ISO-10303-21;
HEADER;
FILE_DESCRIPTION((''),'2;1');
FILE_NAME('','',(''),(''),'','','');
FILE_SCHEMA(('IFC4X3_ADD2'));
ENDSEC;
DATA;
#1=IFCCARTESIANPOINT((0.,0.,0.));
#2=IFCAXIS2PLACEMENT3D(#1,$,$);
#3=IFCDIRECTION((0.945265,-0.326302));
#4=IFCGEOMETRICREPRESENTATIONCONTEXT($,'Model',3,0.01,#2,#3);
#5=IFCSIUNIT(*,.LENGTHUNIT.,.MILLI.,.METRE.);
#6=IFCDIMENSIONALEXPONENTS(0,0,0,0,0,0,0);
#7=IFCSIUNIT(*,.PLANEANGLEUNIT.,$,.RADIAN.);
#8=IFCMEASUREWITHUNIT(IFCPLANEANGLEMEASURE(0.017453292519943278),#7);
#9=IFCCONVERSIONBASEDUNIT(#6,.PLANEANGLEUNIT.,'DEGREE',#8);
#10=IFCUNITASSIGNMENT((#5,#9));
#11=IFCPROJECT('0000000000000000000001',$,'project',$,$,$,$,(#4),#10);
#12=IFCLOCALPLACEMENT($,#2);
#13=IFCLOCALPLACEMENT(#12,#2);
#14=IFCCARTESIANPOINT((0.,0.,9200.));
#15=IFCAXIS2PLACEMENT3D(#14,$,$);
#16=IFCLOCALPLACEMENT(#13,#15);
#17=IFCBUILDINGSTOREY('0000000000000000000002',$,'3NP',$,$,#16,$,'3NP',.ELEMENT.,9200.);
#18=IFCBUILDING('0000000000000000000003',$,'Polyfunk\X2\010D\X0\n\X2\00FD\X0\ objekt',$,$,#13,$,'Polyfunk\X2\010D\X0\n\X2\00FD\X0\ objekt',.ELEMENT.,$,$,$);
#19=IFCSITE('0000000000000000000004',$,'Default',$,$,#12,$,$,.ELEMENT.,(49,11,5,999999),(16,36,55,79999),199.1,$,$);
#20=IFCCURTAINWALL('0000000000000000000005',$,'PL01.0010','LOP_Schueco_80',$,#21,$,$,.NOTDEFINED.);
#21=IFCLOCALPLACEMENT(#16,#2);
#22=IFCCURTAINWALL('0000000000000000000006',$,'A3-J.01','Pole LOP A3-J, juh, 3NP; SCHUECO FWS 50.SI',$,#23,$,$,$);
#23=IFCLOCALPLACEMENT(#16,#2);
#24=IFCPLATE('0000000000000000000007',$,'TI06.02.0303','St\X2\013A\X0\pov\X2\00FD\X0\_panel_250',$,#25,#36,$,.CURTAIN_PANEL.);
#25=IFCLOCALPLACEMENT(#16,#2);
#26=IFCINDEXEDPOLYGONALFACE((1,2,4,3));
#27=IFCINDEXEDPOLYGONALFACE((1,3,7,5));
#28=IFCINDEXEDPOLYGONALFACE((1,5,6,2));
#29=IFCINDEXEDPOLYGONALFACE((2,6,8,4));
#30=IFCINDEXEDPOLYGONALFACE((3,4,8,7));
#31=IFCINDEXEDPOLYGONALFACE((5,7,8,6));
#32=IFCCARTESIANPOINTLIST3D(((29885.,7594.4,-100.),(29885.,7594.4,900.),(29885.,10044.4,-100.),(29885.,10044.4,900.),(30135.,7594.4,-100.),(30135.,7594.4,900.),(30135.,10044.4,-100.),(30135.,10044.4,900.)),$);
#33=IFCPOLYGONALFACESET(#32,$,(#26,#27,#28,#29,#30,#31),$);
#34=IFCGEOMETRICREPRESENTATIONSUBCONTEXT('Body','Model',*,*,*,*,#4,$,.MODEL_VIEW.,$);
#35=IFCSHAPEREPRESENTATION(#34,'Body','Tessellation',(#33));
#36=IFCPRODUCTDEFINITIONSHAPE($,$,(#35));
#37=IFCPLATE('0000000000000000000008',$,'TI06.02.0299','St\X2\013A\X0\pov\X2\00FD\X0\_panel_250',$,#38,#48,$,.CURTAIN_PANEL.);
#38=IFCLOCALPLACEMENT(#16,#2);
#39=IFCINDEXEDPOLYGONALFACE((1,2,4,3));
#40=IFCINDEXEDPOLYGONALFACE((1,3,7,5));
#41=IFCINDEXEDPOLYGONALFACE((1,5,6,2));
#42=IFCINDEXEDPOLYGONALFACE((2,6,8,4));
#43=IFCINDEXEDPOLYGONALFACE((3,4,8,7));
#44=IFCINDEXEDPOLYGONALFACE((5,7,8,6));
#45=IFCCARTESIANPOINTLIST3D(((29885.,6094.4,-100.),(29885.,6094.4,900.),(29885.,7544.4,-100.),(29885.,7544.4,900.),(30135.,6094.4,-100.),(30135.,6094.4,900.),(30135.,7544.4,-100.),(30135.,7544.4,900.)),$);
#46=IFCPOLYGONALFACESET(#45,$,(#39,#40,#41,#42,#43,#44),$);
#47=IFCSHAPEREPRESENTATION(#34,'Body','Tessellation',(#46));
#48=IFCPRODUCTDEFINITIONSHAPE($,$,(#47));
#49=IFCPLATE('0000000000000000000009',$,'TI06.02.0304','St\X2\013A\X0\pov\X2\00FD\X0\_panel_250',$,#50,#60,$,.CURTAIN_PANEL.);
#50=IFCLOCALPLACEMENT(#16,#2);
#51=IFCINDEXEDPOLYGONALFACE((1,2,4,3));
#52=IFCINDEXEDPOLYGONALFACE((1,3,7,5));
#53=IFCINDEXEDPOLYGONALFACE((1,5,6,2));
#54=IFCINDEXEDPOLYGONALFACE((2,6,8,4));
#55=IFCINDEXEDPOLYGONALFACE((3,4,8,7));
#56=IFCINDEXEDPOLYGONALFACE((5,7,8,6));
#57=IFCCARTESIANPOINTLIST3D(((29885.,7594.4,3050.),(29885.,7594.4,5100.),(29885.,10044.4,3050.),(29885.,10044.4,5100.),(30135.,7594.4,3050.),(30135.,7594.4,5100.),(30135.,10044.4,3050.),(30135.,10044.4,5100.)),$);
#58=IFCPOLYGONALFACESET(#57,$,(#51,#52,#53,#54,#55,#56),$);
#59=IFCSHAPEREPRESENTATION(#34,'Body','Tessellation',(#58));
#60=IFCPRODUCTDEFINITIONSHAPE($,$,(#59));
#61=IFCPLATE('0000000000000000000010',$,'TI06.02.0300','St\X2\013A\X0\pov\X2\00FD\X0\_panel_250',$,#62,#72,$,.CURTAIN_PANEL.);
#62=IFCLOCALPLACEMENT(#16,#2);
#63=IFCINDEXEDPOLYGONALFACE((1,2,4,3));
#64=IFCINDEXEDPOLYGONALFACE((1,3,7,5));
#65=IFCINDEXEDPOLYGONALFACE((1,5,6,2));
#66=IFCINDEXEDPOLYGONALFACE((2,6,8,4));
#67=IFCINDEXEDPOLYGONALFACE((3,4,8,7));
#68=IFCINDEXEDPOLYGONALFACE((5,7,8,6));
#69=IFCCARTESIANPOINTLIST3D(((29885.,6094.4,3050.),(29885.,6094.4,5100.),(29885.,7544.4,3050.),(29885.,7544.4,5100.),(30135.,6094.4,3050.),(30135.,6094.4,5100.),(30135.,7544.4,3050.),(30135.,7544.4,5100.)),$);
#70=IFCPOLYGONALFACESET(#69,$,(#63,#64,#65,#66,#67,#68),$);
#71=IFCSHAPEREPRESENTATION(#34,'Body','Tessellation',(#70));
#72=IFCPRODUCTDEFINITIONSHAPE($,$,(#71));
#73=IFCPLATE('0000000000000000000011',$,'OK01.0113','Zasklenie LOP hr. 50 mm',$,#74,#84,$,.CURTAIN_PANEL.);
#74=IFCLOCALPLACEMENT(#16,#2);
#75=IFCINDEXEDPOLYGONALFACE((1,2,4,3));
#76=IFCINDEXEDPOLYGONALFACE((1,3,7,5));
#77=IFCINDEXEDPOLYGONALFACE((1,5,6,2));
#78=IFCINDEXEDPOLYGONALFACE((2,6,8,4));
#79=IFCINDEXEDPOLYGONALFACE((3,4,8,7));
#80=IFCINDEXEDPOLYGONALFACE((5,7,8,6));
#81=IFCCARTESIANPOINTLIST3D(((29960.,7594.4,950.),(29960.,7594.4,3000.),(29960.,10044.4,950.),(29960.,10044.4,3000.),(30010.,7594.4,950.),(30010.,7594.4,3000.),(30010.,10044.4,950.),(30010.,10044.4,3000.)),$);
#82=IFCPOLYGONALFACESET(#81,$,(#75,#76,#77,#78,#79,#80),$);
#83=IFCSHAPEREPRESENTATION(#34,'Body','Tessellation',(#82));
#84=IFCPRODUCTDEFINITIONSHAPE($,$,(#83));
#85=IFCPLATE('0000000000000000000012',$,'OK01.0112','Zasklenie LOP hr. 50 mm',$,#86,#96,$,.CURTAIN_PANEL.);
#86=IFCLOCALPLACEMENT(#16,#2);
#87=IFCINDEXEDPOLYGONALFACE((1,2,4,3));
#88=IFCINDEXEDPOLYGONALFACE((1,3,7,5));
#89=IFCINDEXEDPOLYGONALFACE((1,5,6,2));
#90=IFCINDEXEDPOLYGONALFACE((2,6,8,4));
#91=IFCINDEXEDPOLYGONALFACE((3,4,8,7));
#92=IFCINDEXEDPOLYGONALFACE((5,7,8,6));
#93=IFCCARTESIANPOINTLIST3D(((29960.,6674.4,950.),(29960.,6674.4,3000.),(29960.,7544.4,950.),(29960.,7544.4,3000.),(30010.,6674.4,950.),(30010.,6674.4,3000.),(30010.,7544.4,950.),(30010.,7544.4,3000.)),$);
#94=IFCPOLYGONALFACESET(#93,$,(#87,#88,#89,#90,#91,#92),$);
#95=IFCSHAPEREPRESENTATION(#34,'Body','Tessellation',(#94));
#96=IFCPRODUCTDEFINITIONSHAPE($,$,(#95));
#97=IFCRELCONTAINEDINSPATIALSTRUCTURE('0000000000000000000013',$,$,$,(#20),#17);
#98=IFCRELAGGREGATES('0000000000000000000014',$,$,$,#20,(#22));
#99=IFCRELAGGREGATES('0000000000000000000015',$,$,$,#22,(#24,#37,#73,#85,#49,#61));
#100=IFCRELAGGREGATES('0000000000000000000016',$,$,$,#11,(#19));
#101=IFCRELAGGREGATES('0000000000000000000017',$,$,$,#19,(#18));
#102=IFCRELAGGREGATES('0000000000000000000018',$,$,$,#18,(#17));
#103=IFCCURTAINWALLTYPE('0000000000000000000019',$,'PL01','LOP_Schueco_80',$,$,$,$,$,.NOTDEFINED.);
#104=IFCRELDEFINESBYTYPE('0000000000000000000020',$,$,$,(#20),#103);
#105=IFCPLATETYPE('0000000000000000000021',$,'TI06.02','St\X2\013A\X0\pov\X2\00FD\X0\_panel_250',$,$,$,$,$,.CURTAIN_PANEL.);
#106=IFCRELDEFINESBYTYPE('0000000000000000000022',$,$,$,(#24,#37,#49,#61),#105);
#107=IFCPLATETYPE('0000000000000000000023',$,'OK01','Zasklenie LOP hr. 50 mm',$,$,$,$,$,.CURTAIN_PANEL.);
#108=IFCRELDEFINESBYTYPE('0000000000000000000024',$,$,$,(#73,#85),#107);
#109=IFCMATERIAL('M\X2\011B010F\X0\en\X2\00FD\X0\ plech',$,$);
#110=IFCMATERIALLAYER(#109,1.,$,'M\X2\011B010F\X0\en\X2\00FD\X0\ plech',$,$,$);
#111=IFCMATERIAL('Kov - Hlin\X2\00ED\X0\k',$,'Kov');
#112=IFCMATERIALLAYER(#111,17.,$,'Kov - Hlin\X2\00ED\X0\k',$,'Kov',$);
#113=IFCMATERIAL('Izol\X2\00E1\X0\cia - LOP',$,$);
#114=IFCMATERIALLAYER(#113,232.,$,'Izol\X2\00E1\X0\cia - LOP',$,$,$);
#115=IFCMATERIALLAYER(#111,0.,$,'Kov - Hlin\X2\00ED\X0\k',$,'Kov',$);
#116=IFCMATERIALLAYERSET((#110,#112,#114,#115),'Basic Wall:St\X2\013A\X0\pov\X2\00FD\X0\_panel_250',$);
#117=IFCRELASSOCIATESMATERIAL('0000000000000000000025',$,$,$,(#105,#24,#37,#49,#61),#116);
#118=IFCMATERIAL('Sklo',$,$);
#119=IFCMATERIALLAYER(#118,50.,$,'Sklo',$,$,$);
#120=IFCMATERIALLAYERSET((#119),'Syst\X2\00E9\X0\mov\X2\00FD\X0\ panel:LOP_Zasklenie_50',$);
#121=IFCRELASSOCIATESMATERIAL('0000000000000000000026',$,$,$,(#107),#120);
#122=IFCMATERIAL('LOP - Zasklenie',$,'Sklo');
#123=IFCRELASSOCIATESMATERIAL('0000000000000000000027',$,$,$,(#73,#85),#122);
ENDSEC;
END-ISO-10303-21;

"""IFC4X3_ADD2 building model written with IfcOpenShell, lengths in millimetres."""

from ifc_helpers import new_model, entity, si_unit, converted_unit, direction, frame, frame_2d, origin, origin_2d_with_axis, place, context, subcontext, project, spatial, rectangle, extrude, source, transform, mapped, material, layer, layer_set, layer_usage, type_object, type_shapes, element, aggregate, save


model = new_model("IFC4X3_ADD2")

# Units and contexts
model_context = context("Model", 3, precision=0.01, world=origin(), true_north=direction((0.945265, -0.326302)))
body_context = subcontext(model_context, "Body", "Model", "MODEL_VIEW")
ifc_project = project(units=[si_unit("LENGTHUNIT", "METRE", prefix="MILLI"), converted_unit("PLANEANGLEUNIT", "DEGREE", entity("IfcPlaneAngleMeasure", 0.017453292519943278), si_unit("PLANEANGLEUNIT", "RADIAN"), dimensions=[0, 0, 0, 0, 0, 0, 0])], contexts=[model_context])

# Site, building, storey
site_placement = place(None, origin())
site = spatial("IfcSite", under=ifc_project, at=site_placement, Name="Default", CompositionType="ELEMENT", RefLatitude=(49, 11, 5, 999999), RefLongitude=(16, 36, 55, 79999), RefElevation=199.1)
building_placement = place(site_placement, origin())
building = spatial("IfcBuilding", under=site, at=building_placement, Name="Polyfunkčný objekt", LongName="Polyfunkčný objekt", CompositionType="ELEMENT")
storey_placement = place(building_placement, frame((0.0, 0.0, 9200.0)))
storey = spatial("IfcBuildingStorey", under=building, at=storey_placement, Name="3NP", LongName="3NP", CompositionType="ELEMENT", Elevation=9200.0)

# Curtain walls, plates
curtain_wall_type = type_object("IfcCurtainWallType", Name="PL01", Description="LOP_Schueco_80", PredefinedType="NOTDEFINED")
curtain_wall_1_placement = place(storey_placement, frame((0.0, 0.0, -9200.0)))
curtain_wall_1 = element("IfcCurtainWall", 1, at=curtain_wall_1_placement, inside=storey, type_object=curtain_wall_type, Name="PL01.0010", Description="LOP_Schueco_80", PredefinedType="NOTDEFINED")
curtain_wall_2 = element("IfcCurtainWall", 2, Name="A3-J.01", Description="Pole LOP A3-J, juh, 3NP; SCHUECO FWS 50.SI")
aggregate(curtain_wall_1, [curtain_wall_2])
ifc_material_1 = material(Name="Měďený plech")
ifc_layer_1 = layer(ifc_material_1, 1.0, Name="Měďený plech")
ifc_material_2 = material(Name="Kov - Hliník", Category="Kov")
ifc_layer_2 = layer(ifc_material_2, 17.0, Name="Kov - Hliník", Category="Kov")
ifc_material_3 = material(Name="Izolácia - LOP")
ifc_layer_3 = layer(ifc_material_3, 232.0, Name="Izolácia - LOP")
ifc_layer_4 = layer(ifc_material_2, 0.0, Name="Kov - Hliník", Category="Kov")
ifc_layer_set_1 = layer_set([ifc_layer_1, ifc_layer_2, ifc_layer_3, ifc_layer_4], Name="Basic Wall:Stĺpový_panel_250")
ifc_layer_usage_1 = layer_usage(ifc_layer_set_1, "AXIS2", "POSITIVE", -125.0)
plate_type_1 = type_object("IfcPlateType", Name="TI06.02", Description="Stĺpový_panel_250", PredefinedType="CURTAIN_PANEL", material=ifc_layer_set_1)
plate_1_placement = place(storey_placement, frame((30010.0, 10044.4, -100.0), z_axis=(0.0, 0.0, 1.0), x_axis=(0.0, -1.0, 0.0)))
plate_1 = element("IfcPlate", 3, at=plate_1_placement, type_object=plate_type_1, material=ifc_layer_usage_1, Name="TI06.02.0303", Description="Stĺpový_panel_250", PredefinedType="CURTAIN_PANEL", context=body_context, shape_type="SweptSolid", body=[
    extrude(rectangle(XDim=250.0, YDim=2450.0, at=origin_2d_with_axis()), frame((1225.0, 0.0, 0.0), z_axis=(0.0, 0.0, 1.0), x_axis=(0.0, 1.0, 0.0)), (0.0, 0.0, 1.0), 1000.0),
])
ifc_layer_usage_2 = layer_usage(ifc_layer_set_1, "AXIS2", "POSITIVE", -125.0)
plate_2_placement = place(storey_placement, frame((30010.0, 7544.4, -100.0), z_axis=(0.0, 0.0, 1.0), x_axis=(0.0, -1.0, 0.0)))
plate_2 = element("IfcPlate", 4, at=plate_2_placement, type_object=plate_type_1, material=ifc_layer_usage_2, Name="TI06.02.0299", Description="Stĺpový_panel_250", PredefinedType="CURTAIN_PANEL", context=body_context, shape_type="SweptSolid", body=[
    extrude(rectangle(XDim=250.0, YDim=1450.0, at=frame_2d((0.0, 0.0), x_axis=(1.0, 0.0))), frame((725.0, 0.0, 0.0), z_axis=(0.0, 0.0, 1.0), x_axis=(0.0, 1.0, 0.0)), (0.0, 0.0, 1.0), 1000.0),
])
ifc_layer_usage_3 = layer_usage(ifc_layer_set_1, "AXIS2", "POSITIVE", -125.0)
plate_3_placement = place(storey_placement, frame((30010.0, 10044.4, 3050.0), z_axis=(0.0, 0.0, 1.0), x_axis=(0.0, -1.0, 0.0)))
plate_3 = element("IfcPlate", 5, at=plate_3_placement, type_object=plate_type_1, material=ifc_layer_usage_3, Name="TI06.02.0304", Description="Stĺpový_panel_250", PredefinedType="CURTAIN_PANEL", context=body_context, shape_type="SweptSolid", body=[
    extrude(rectangle(XDim=250.0, YDim=2450.0, at=frame_2d((0.0, 0.0), x_axis=(1.0, 0.0))), frame((1225.0, 0.0, 0.0), z_axis=(0.0, 0.0, 1.0), x_axis=(0.0, 1.0, 0.0)), (0.0, 0.0, 1.0), 2050.0),
])
ifc_layer_usage_4 = layer_usage(ifc_layer_set_1, "AXIS2", "POSITIVE", -125.0)
plate_4_placement = place(storey_placement, frame((30010.0, 7544.4, 3050.0), z_axis=(0.0, 0.0, 1.0), x_axis=(0.0, -1.0, 0.0)))
plate_4 = element("IfcPlate", 6, at=plate_4_placement, type_object=plate_type_1, material=ifc_layer_usage_4, Name="TI06.02.0300", Description="Stĺpový_panel_250", PredefinedType="CURTAIN_PANEL", context=body_context, shape_type="SweptSolid", body=[
    extrude(rectangle(XDim=250.0, YDim=1450.0, at=frame_2d((0.0, 0.0), x_axis=(1.0, 0.0))), frame((725.0, 0.0, 0.0), z_axis=(0.0, 0.0, 1.0), x_axis=(0.0, 1.0, 0.0)), (0.0, 0.0, 1.0), 2050.0),
])
ifc_material_4 = material(Name="LOP - Zasklenie", Category="Sklo")
ifc_material_5 = material(Name="Sklo")
ifc_layer_5 = layer(ifc_material_5, 50.0, Name="Sklo")
ifc_layer_set_2 = layer_set([ifc_layer_5], Name="Systémový panel:LOP_Zasklenie_50")
plate_type_2 = type_object("IfcPlateType", Name="OK01", Description="Zasklenie LOP hr. 50 mm", PredefinedType="CURTAIN_PANEL", material=ifc_layer_set_2)
shared_shape_1 = source(origin(), body_context, "Body", "SweptSolid", [
    extrude(rectangle(XDim=50.0, YDim=2450.0, at=origin_2d_with_axis()), frame((0.0, -25.0, 0.0), z_axis=(0.0, 0.0, 1.0), x_axis=(0.0, 1.0, 0.0)), (0.0, 0.0, 1.0), 2050.0),
])
plate_5_placement = place(curtain_wall_1_placement, frame((30010.0, 8819.4, 10150.0), z_axis=(0.0, 0.0, 1.0), x_axis=(0.0, -1.0, 0.0)))
plate_5 = element("IfcPlate", 7, at=plate_5_placement, type_object=plate_type_2, material=ifc_material_4, Name="OK01.0113", Description="Zasklenie LOP hr. 50 mm", PredefinedType="CURTAIN_PANEL", context=body_context, shape_type="MappedRepresentation", body=[
    mapped(shared_shape_1, transform((0.0, 0.0, 0.0), scale=1.0)),
])
shared_shape_2 = source(origin(), body_context, "Body", "SweptSolid", [
    extrude(rectangle(XDim=50.0, YDim=870.0, at=origin_2d_with_axis()), frame((0.0, -25.0, 0.0), z_axis=(0.0, 0.0, 1.0), x_axis=(0.0, 1.0, 0.0)), (0.0, 0.0, 1.0), 2050.0),
])
type_shapes(plate_type_2, [shared_shape_1, shared_shape_2])
plate_6_placement = place(curtain_wall_1_placement, frame((30010.0, 7109.4, 10150.0), z_axis=(0.0, 0.0, 1.0), x_axis=(0.0, -1.0, 0.0)))
plate_6 = element("IfcPlate", 8, at=plate_6_placement, type_object=plate_type_2, material=ifc_material_4, Name="OK01.0112", Description="Zasklenie LOP hr. 50 mm", PredefinedType="CURTAIN_PANEL", context=body_context, shape_type="MappedRepresentation", body=[
    mapped(shared_shape_2, transform((0.0, 0.0, 0.0), scale=1.0)),
])
aggregate(curtain_wall_2, [plate_1, plate_2, plate_5, plate_6, plate_3, plate_4])

save(model, "model.ifc")
